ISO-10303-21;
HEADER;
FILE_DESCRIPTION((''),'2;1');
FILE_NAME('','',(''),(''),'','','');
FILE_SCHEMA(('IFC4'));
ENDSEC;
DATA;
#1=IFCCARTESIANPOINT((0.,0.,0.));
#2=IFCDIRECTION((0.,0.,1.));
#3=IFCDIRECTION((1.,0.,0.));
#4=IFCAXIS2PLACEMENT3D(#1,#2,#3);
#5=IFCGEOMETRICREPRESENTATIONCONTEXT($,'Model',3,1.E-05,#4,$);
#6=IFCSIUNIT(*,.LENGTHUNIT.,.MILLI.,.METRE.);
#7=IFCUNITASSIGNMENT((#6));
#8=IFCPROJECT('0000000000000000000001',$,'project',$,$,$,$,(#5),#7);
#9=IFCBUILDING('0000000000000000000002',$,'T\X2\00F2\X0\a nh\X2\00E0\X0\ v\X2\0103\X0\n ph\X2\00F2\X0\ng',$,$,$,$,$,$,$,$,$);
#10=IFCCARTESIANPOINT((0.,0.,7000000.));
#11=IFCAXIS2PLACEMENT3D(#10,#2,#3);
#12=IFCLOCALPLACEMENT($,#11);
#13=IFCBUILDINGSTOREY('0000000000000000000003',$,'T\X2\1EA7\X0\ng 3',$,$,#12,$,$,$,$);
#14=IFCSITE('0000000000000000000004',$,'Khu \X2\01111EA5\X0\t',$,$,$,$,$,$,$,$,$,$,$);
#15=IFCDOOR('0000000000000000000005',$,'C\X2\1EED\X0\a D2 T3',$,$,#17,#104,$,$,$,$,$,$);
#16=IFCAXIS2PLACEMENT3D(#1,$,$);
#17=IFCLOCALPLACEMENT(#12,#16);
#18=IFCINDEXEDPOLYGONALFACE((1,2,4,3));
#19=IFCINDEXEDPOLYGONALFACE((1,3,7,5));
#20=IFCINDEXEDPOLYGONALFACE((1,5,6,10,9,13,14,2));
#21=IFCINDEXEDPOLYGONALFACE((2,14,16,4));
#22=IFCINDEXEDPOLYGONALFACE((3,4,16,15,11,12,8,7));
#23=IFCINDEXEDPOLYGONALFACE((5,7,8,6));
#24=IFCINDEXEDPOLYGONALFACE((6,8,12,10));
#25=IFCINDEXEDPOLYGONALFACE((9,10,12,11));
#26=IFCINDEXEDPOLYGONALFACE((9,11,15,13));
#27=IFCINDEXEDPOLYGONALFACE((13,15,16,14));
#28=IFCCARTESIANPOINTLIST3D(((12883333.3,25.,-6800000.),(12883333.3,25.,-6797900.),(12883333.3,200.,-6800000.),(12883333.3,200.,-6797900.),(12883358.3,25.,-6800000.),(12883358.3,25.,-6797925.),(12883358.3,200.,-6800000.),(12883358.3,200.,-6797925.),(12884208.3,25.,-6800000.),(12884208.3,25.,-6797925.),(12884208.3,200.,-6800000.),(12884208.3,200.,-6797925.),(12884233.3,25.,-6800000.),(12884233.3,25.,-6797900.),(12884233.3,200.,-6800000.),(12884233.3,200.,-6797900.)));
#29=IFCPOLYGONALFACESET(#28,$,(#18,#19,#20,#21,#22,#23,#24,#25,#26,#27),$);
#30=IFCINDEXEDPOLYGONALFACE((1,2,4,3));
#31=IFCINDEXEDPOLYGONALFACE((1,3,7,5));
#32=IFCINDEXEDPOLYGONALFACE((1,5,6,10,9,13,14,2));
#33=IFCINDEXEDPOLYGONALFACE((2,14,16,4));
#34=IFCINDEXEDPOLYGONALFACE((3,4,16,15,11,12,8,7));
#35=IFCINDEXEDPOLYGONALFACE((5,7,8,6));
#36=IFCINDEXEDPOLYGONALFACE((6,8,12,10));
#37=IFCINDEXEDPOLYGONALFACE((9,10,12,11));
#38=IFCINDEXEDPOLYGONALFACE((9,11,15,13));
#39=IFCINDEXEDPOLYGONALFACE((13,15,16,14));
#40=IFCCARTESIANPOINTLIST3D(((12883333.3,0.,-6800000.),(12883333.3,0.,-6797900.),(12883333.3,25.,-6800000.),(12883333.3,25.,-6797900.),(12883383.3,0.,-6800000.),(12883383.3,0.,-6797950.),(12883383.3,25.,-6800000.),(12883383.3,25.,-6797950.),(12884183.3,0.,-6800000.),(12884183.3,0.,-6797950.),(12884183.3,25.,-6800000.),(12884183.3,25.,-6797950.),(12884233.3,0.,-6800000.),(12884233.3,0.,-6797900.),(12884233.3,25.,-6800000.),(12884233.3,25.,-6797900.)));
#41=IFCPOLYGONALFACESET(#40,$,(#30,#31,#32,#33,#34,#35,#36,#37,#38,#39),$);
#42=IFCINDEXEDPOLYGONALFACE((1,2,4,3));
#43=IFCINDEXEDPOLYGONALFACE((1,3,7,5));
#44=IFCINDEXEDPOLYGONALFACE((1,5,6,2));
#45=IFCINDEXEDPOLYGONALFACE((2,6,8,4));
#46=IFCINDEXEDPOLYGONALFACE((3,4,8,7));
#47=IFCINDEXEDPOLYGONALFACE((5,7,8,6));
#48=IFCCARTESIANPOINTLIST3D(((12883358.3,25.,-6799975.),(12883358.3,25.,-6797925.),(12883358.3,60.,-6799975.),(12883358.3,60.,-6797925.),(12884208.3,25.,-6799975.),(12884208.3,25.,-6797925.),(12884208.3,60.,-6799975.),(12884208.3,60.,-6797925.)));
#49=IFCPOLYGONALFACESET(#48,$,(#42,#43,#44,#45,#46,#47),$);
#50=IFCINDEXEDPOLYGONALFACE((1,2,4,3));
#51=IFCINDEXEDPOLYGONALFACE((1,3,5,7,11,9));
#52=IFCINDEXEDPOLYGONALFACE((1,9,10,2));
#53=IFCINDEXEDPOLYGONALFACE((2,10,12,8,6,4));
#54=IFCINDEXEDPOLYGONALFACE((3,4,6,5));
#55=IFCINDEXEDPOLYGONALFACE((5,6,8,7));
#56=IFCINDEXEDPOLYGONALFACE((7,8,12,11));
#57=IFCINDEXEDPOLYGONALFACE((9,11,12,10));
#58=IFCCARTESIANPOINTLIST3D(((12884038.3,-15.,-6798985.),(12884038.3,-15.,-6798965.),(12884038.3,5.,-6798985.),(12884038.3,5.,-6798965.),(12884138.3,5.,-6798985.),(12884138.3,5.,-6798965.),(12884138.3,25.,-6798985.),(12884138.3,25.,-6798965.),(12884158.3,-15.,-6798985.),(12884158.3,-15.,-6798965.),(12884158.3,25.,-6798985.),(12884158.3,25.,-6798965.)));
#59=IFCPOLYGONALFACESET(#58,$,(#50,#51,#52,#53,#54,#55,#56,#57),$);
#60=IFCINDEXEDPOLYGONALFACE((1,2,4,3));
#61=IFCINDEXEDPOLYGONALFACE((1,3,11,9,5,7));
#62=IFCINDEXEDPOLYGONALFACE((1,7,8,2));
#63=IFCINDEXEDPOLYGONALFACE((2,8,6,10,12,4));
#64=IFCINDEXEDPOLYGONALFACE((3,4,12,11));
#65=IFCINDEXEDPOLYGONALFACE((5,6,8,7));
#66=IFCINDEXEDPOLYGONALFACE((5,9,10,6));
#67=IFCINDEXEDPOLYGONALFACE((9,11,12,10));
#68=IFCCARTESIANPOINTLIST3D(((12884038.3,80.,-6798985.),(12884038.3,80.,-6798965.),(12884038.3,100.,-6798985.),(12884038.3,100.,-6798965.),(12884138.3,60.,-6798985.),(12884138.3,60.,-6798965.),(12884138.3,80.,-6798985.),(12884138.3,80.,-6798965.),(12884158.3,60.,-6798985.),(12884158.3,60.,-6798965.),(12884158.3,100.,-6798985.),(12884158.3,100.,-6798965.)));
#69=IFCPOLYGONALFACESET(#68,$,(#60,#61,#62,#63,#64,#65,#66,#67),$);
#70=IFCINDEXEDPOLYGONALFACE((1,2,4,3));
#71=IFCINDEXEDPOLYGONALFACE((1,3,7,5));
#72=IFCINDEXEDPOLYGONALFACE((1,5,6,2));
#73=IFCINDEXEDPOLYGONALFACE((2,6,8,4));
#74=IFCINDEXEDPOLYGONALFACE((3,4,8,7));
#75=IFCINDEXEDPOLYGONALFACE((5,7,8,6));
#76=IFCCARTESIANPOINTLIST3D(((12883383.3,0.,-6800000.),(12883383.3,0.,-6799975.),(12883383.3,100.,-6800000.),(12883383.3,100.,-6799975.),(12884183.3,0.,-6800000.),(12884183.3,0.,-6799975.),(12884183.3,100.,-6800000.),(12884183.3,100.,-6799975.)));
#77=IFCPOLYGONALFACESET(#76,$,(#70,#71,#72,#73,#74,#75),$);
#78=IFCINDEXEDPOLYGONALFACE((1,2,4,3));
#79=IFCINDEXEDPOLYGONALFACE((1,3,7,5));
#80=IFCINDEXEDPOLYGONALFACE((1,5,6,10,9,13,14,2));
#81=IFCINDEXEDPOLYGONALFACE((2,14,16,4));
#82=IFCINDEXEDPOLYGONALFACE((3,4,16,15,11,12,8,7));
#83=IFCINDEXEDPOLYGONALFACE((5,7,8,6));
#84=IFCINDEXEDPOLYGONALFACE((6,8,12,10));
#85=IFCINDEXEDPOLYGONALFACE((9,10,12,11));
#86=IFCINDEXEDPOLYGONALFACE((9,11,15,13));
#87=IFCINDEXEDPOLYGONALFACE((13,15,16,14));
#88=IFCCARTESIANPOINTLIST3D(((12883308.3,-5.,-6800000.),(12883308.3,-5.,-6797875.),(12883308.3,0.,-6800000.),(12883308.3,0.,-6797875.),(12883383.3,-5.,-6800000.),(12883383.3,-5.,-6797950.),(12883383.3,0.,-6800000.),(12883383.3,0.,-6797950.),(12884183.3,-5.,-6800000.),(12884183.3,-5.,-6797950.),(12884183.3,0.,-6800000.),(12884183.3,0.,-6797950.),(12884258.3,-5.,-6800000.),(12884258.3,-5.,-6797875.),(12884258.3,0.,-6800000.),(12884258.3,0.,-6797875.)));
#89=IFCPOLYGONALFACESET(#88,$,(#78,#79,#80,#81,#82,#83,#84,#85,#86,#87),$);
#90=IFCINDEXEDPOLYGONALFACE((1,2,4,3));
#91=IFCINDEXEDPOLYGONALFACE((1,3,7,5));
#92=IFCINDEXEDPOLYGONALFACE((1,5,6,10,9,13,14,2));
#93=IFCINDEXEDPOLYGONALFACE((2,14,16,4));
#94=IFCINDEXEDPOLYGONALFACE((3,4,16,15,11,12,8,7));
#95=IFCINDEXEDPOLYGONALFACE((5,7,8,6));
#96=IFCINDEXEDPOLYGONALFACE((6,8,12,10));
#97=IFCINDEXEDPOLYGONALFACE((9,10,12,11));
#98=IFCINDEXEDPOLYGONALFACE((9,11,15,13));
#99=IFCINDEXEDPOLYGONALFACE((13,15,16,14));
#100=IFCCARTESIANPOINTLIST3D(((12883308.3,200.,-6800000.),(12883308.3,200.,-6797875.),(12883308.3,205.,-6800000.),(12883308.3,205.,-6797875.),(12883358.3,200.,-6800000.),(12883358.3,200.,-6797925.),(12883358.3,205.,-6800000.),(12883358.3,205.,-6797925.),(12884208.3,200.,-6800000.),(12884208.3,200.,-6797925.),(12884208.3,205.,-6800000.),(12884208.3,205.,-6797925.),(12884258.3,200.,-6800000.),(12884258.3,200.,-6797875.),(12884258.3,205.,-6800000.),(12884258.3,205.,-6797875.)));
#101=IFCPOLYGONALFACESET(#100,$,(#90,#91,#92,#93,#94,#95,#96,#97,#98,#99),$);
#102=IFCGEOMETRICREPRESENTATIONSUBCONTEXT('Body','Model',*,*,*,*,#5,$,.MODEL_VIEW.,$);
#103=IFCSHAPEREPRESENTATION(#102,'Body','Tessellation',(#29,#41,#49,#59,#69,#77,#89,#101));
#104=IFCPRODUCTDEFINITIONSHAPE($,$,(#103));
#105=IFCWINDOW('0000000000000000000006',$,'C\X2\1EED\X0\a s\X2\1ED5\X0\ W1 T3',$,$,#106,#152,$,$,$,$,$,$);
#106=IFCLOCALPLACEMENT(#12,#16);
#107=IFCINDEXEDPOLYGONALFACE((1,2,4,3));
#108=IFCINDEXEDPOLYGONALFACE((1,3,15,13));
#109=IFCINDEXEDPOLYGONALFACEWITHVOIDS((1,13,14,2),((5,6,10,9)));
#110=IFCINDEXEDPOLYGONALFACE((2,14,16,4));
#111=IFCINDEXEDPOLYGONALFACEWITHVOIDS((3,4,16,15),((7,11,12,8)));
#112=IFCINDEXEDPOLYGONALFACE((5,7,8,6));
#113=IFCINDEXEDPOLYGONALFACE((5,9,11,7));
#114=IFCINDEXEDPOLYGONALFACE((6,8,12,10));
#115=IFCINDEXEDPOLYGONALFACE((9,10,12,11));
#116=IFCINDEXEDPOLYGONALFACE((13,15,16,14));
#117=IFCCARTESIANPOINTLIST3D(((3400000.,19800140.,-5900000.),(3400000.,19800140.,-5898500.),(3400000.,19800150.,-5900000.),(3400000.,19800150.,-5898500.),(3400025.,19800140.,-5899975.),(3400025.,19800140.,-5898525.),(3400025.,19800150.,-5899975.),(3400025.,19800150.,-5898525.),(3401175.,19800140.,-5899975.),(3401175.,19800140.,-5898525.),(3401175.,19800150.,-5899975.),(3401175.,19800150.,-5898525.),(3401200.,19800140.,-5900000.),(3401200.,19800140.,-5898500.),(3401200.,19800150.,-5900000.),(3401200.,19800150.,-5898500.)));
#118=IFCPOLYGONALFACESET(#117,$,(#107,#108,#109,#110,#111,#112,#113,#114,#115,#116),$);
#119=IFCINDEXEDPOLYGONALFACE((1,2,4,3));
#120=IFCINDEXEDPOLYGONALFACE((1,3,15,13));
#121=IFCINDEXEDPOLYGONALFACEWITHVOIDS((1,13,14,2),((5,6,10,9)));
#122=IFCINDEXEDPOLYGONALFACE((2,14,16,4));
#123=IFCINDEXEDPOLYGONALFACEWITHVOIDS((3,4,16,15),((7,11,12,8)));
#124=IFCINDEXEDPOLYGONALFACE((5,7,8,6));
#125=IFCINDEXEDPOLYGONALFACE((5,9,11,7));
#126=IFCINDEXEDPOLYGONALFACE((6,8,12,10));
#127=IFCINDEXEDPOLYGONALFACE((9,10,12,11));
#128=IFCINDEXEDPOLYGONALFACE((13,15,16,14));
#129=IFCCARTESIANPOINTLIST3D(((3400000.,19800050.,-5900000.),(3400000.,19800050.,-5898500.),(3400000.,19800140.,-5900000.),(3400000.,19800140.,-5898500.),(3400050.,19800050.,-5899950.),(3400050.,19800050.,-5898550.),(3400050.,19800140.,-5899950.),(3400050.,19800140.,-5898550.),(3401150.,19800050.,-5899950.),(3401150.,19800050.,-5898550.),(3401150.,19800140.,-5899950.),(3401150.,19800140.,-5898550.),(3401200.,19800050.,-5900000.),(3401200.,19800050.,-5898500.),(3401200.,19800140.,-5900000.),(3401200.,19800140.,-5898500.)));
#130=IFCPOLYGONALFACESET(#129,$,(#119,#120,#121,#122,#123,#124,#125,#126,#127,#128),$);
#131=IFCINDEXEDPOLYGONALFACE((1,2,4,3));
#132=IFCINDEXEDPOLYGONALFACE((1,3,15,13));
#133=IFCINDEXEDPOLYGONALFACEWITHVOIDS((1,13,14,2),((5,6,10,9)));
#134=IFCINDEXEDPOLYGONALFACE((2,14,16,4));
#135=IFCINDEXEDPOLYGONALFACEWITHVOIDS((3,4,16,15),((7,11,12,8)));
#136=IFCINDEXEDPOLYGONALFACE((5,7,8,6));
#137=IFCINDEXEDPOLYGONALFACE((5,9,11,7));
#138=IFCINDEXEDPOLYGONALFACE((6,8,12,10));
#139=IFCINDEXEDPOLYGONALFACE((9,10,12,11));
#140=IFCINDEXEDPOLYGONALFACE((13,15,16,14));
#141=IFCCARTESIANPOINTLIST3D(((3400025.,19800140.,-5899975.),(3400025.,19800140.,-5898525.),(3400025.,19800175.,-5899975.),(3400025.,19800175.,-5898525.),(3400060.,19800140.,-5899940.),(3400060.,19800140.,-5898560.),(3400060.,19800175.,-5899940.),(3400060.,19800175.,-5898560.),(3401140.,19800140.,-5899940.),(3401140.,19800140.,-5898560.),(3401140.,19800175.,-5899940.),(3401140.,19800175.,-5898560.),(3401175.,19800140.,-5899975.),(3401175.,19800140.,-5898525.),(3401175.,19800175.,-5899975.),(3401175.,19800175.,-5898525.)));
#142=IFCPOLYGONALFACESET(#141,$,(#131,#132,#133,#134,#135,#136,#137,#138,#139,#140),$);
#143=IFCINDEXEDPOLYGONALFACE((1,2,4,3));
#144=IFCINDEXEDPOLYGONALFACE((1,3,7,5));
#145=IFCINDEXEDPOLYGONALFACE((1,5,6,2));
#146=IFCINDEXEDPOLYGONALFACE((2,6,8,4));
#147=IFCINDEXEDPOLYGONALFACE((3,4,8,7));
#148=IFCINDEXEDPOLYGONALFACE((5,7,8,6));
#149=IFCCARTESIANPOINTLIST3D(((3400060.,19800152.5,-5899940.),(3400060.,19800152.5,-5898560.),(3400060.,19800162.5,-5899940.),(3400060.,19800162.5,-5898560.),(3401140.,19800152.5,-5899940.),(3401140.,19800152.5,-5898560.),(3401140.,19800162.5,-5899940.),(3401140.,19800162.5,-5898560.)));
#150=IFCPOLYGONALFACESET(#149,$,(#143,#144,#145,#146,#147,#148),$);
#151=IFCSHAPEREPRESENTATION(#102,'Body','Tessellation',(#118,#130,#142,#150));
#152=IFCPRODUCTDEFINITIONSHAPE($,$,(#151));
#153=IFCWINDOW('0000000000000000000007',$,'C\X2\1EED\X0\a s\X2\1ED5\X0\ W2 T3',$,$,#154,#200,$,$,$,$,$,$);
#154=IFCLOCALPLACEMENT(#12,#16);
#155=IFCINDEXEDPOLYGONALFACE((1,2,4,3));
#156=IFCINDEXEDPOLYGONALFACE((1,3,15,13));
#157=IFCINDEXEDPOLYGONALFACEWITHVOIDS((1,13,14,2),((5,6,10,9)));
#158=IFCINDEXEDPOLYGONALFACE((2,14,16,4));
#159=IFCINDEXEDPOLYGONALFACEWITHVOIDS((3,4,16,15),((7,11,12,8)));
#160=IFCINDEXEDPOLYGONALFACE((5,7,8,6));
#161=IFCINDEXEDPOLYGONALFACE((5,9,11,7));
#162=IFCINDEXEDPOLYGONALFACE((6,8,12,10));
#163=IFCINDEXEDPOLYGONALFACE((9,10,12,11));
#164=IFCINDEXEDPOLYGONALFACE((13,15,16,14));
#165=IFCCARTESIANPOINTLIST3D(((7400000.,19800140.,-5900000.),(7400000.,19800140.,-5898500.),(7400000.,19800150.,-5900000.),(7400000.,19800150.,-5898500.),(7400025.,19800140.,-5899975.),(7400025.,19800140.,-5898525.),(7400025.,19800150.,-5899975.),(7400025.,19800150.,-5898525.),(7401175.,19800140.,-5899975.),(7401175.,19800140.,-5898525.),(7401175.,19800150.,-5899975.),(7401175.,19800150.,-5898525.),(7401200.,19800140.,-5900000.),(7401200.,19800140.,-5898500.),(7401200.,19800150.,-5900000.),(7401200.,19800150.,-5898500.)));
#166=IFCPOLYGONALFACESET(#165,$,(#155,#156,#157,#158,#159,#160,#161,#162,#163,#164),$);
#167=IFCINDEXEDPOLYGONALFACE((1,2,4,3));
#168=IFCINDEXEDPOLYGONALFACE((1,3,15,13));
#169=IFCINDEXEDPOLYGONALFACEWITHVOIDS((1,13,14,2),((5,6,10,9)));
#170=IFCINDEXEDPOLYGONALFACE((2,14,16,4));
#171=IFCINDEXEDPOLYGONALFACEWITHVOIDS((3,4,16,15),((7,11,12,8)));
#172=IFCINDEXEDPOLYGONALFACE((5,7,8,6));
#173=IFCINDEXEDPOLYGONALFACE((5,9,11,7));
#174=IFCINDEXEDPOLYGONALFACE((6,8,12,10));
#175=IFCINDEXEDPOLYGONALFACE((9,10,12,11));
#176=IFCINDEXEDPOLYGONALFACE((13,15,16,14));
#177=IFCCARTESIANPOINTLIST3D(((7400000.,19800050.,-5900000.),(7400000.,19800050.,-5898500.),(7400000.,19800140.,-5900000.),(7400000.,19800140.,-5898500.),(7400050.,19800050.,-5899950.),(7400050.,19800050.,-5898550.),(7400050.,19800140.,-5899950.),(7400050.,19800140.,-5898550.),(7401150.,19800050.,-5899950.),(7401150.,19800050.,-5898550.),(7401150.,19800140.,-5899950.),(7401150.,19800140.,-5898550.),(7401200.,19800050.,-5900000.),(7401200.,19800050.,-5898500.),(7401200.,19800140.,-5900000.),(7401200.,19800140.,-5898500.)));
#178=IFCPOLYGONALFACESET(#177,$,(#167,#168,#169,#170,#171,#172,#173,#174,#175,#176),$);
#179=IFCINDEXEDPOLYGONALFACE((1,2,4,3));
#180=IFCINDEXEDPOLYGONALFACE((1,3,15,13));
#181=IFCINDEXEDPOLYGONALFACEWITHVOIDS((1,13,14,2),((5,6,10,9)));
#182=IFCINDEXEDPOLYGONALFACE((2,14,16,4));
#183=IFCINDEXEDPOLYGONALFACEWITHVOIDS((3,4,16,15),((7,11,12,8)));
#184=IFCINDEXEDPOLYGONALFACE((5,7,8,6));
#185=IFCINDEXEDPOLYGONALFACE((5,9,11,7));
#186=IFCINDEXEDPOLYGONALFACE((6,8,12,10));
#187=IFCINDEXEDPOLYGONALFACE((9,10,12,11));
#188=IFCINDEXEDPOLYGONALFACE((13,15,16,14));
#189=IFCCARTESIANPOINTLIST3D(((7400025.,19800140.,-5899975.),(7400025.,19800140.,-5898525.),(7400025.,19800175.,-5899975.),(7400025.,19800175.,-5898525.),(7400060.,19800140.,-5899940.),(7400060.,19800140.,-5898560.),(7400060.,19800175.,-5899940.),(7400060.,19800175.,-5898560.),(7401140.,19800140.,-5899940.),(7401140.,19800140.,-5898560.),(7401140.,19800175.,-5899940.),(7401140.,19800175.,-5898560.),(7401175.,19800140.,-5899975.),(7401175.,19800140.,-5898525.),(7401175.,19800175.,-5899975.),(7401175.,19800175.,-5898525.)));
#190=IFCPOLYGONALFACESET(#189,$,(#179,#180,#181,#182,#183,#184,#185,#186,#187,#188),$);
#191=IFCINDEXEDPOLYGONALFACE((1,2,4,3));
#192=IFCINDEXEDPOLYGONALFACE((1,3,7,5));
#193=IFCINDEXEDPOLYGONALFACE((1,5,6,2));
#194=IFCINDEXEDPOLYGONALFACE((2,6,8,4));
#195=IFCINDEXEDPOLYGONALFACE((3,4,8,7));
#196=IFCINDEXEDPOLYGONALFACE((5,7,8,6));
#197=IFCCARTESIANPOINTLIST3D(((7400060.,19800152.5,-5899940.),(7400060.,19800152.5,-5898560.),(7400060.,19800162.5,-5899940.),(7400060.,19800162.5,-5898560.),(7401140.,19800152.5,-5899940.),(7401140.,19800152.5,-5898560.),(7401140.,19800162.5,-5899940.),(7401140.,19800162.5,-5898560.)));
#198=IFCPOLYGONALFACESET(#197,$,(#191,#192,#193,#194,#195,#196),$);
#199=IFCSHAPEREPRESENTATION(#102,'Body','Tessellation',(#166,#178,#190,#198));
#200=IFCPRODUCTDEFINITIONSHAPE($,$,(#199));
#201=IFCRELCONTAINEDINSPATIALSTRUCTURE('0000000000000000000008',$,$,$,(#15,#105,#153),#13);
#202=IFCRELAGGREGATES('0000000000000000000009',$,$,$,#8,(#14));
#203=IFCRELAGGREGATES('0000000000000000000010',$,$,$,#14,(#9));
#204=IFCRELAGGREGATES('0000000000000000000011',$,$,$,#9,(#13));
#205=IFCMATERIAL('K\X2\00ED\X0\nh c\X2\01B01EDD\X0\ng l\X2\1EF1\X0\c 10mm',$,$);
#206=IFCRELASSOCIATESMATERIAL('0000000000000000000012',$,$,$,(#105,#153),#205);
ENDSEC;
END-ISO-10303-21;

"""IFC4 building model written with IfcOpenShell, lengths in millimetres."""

from ifc_helpers import new_model, si_unit, frame, origin_with_axes, place, context, subcontext, project, spatial, line, indexed_curve, outline, extrude, material, element, save


model = new_model("IFC4")

# Units and contexts
model_context = context("Model", 3, precision=1e-05, world=origin_with_axes())
body_context = subcontext(model_context, "Body", "Model", "MODEL_VIEW")
ifc_project = project(units=[si_unit("LENGTHUNIT", "METRE", prefix="MILLI")], contexts=[model_context])

# Site, building, storey
site = spatial("IfcSite", under=ifc_project, Name="Khu đất")
building = spatial("IfcBuilding", under=site, Name="Tòa nhà văn phòng")
storey_placement = place(None, frame((0.0, 0.0, 7000000.0), z_axis=(0.0, 0.0, 1.0), x_axis=(1.0, 0.0, 0.0)))
storey = spatial("IfcBuildingStorey", under=building, at=storey_placement, Name="Tầng 3")

# Door
door_1_placement = place(storey_placement, frame((12883333.3, 0.0, -6800000.0), z_axis=(0.0, 0.0, 1.0), x_axis=(1.0, 0.0, 0.0)))
element("IfcDoor", 1, at=door_1_placement, inside=storey, Name="Cửa D2 T3", context=body_context, shape_type="SolidModel", body=[
    extrude(outline(indexed_curve([(0.0, 0.0), (0.0, 2100.0), (900.0, 2100.0), (900.0, 0.0), (875.0, 0.0), (875.0, 2075.0), (25.0, 2075.0), (25.0, 0.0)], segments=[line(1, 2, 3, 4, 5, 6, 7, 8, 1)])), frame((0.0, 25.0, 0.0), z_axis=(0.0, -1.0, 0.0), x_axis=(1.0, 0.0, 0.0)), (0.0, 0.0, -1.0), 175.0),
    extrude(outline(indexed_curve([(0.0, 0.0), (0.0, 2100.0), (900.0, 2100.0), (900.0, 0.0), (850.0, 0.0), (850.0, 2050.0), (50.0, 2050.0), (50.0, 0.0)], segments=[line(1, 2, 3, 4, 5, 6, 7, 8, 1)])), frame((0.0, 0.0, 0.0), z_axis=(0.0, -1.0, 0.0), x_axis=(1.0, 0.0, 0.0)), (0.0, 0.0, -1.0), 25.0),
    extrude(outline(indexed_curve([(0.0, 0.0), (850.0, 0.0), (850.0, 35.0), (0.0, 35.0)], segments=[line(1, 2, 3, 4, 1)])), frame((25.0, 25.0, 25.0), z_axis=(0.0, 0.0, 1.0), x_axis=(1.0, 0.0, 0.0)), (0.0, 0.0, 1.0), 2050.0),
    extrude(outline(indexed_curve([(0.0, 0.0), (0.0, -40.0), (-120.0, -40.0), (-120.0, -20.0), (-20.0, -20.0), (-20.0, 0.0)], segments=[line(1, 2, 3, 4, 5, 6, 1)])), frame((825.0, 25.0, 1015.0), z_axis=(0.0, 0.0, 1.0), x_axis=(1.0, 0.0, 0.0)), (0.0, 0.0, 1.0), 20.0),
    extrude(outline(indexed_curve([(0.0, 0.0), (0.0, 40.0), (-120.0, 40.0), (-120.0, 20.0), (-20.0, 20.0), (-20.0, 0.0)], segments=[line(1, 2, 3, 4, 5, 6, 1)])), frame((825.0, 60.0, 1015.0), z_axis=(0.0, 0.0, 1.0), x_axis=(1.0, 0.0, 0.0)), (0.0, 0.0, 1.0), 20.0),
    extrude(outline(indexed_curve([(0.0, 0.0), (800.0, 0.0), (800.0, 100.0), (0.0, 100.0)], segments=[line(1, 2, 3, 4, 1)])), frame((50.0, 0.0, 0.0), z_axis=(0.0, 0.0, 1.0), x_axis=(1.0, 0.0, 0.0)), (0.0, 0.0, 1.0), 25.0),
    extrude(outline(indexed_curve([(0.0, 0.0), (0.0, 2125.0), (950.0, 2125.0), (950.0, 0.0), (875.0, 0.0), (875.0, 2050.0), (75.0, 2050.0), (75.0, 0.0)], segments=[line(1, 2, 3, 4, 5, 6, 7, 8, 1)])), frame((-25.0, -5.0, 0.0), z_axis=(0.0, -1.0, 0.0), x_axis=(1.0, 0.0, 0.0)), (0.0, 0.0, -1.0), 5.0),
    extrude(outline(indexed_curve([(0.0, 0.0), (0.0, 2125.0), (950.0, 2125.0), (950.0, 0.0), (900.0, 0.0), (900.0, 2075.0), (50.0, 2075.0), (50.0, 0.0)], segments=[line(1, 2, 3, 4, 5, 6, 7, 8, 1)])), frame((-25.0, 200.0, 0.0), z_axis=(0.0, -1.0, 0.0), x_axis=(1.0, 0.0, 0.0)), (0.0, 0.0, -1.0), 5.0),
])

# Windows
ifc_material_1 = material(Name="Kính cường lực 10mm")
for number, where, z_axis, x_axis, name in (
    (2, (3400000.0, 19800000.0, -5900000.0), (0.0, 0.0, 1.0), (1.0, 0.0, 0.0), "Cửa sổ W1 T3"),
    (3, (7400000.0, 19800000.0, -5900000.0), (0.0, 0.0, 1.0), (1.0, 0.0, 0.0), "Cửa sổ W2 T3"),
):
    element("IfcWindow", number, at=place(storey_placement, frame(where, z_axis=z_axis, x_axis=x_axis)), inside=storey, material=ifc_material_1, Name=name, context=body_context, shape_type="SolidModel", body=[
        extrude(outline(indexed_curve([(0.0, 0.0), (1200.0, 0.0), (1200.0, 1500.0), (0.0, 1500.0)], segments=[line(1, 2, 3, 4, 1)]), holes=[indexed_curve([(25.0, 25.0), (1175.0, 25.0), (1175.0, 1475.0), (25.0, 1475.0)], segments=[line(1, 2, 3, 4, 1)])]), frame((0.0, 140.0, 0.0), z_axis=(0.0, -1.0, 0.0), x_axis=(1.0, 0.0, 0.0)), (0.0, 0.0, -1.0), 10.0),
        extrude(outline(indexed_curve([(0.0, 0.0), (1200.0, 0.0), (1200.0, 1500.0), (0.0, 1500.0)], segments=[line(1, 2, 3, 4, 1)]), holes=[indexed_curve([(50.0, 50.0), (1150.0, 50.0), (1150.0, 1450.0), (50.0, 1450.0)], segments=[line(1, 2, 3, 4, 1)])]), frame((0.0, 50.0, 0.0), z_axis=(0.0, -1.0, 0.0), x_axis=(1.0, 0.0, 0.0)), (0.0, 0.0, -1.0), 90.0),
        extrude(outline(indexed_curve([(0.0, 0.0), (1150.0, 0.0), (1150.0, 1450.0), (0.0, 1450.0)], segments=[line(1, 2, 3, 4, 1)]), holes=[indexed_curve([(35.0, 35.0), (1115.0, 35.0), (1115.0, 1415.0), (35.0, 1415.0)], segments=[line(1, 2, 3, 4, 1)])]), frame((25.0, 140.0, 25.0), z_axis=(0.0, -1.0, 0.0), x_axis=(1.0, 0.0, 0.0)), (0.0, 0.0, -1.0), 35.0),
        extrude(outline(indexed_curve([(35.0, 35.0), (1115.0, 35.0), (1115.0, 1415.0), (35.0, 1415.0)], segments=[line(1, 2, 3, 4, 1)])), frame((25.0, 152.5, 25.0), z_axis=(0.0, -1.0, 0.0), x_axis=(1.0, 0.0, 0.0)), (0.0, 0.0, -1.0), 10.0),
    ])

save(model, "model.ifc")
